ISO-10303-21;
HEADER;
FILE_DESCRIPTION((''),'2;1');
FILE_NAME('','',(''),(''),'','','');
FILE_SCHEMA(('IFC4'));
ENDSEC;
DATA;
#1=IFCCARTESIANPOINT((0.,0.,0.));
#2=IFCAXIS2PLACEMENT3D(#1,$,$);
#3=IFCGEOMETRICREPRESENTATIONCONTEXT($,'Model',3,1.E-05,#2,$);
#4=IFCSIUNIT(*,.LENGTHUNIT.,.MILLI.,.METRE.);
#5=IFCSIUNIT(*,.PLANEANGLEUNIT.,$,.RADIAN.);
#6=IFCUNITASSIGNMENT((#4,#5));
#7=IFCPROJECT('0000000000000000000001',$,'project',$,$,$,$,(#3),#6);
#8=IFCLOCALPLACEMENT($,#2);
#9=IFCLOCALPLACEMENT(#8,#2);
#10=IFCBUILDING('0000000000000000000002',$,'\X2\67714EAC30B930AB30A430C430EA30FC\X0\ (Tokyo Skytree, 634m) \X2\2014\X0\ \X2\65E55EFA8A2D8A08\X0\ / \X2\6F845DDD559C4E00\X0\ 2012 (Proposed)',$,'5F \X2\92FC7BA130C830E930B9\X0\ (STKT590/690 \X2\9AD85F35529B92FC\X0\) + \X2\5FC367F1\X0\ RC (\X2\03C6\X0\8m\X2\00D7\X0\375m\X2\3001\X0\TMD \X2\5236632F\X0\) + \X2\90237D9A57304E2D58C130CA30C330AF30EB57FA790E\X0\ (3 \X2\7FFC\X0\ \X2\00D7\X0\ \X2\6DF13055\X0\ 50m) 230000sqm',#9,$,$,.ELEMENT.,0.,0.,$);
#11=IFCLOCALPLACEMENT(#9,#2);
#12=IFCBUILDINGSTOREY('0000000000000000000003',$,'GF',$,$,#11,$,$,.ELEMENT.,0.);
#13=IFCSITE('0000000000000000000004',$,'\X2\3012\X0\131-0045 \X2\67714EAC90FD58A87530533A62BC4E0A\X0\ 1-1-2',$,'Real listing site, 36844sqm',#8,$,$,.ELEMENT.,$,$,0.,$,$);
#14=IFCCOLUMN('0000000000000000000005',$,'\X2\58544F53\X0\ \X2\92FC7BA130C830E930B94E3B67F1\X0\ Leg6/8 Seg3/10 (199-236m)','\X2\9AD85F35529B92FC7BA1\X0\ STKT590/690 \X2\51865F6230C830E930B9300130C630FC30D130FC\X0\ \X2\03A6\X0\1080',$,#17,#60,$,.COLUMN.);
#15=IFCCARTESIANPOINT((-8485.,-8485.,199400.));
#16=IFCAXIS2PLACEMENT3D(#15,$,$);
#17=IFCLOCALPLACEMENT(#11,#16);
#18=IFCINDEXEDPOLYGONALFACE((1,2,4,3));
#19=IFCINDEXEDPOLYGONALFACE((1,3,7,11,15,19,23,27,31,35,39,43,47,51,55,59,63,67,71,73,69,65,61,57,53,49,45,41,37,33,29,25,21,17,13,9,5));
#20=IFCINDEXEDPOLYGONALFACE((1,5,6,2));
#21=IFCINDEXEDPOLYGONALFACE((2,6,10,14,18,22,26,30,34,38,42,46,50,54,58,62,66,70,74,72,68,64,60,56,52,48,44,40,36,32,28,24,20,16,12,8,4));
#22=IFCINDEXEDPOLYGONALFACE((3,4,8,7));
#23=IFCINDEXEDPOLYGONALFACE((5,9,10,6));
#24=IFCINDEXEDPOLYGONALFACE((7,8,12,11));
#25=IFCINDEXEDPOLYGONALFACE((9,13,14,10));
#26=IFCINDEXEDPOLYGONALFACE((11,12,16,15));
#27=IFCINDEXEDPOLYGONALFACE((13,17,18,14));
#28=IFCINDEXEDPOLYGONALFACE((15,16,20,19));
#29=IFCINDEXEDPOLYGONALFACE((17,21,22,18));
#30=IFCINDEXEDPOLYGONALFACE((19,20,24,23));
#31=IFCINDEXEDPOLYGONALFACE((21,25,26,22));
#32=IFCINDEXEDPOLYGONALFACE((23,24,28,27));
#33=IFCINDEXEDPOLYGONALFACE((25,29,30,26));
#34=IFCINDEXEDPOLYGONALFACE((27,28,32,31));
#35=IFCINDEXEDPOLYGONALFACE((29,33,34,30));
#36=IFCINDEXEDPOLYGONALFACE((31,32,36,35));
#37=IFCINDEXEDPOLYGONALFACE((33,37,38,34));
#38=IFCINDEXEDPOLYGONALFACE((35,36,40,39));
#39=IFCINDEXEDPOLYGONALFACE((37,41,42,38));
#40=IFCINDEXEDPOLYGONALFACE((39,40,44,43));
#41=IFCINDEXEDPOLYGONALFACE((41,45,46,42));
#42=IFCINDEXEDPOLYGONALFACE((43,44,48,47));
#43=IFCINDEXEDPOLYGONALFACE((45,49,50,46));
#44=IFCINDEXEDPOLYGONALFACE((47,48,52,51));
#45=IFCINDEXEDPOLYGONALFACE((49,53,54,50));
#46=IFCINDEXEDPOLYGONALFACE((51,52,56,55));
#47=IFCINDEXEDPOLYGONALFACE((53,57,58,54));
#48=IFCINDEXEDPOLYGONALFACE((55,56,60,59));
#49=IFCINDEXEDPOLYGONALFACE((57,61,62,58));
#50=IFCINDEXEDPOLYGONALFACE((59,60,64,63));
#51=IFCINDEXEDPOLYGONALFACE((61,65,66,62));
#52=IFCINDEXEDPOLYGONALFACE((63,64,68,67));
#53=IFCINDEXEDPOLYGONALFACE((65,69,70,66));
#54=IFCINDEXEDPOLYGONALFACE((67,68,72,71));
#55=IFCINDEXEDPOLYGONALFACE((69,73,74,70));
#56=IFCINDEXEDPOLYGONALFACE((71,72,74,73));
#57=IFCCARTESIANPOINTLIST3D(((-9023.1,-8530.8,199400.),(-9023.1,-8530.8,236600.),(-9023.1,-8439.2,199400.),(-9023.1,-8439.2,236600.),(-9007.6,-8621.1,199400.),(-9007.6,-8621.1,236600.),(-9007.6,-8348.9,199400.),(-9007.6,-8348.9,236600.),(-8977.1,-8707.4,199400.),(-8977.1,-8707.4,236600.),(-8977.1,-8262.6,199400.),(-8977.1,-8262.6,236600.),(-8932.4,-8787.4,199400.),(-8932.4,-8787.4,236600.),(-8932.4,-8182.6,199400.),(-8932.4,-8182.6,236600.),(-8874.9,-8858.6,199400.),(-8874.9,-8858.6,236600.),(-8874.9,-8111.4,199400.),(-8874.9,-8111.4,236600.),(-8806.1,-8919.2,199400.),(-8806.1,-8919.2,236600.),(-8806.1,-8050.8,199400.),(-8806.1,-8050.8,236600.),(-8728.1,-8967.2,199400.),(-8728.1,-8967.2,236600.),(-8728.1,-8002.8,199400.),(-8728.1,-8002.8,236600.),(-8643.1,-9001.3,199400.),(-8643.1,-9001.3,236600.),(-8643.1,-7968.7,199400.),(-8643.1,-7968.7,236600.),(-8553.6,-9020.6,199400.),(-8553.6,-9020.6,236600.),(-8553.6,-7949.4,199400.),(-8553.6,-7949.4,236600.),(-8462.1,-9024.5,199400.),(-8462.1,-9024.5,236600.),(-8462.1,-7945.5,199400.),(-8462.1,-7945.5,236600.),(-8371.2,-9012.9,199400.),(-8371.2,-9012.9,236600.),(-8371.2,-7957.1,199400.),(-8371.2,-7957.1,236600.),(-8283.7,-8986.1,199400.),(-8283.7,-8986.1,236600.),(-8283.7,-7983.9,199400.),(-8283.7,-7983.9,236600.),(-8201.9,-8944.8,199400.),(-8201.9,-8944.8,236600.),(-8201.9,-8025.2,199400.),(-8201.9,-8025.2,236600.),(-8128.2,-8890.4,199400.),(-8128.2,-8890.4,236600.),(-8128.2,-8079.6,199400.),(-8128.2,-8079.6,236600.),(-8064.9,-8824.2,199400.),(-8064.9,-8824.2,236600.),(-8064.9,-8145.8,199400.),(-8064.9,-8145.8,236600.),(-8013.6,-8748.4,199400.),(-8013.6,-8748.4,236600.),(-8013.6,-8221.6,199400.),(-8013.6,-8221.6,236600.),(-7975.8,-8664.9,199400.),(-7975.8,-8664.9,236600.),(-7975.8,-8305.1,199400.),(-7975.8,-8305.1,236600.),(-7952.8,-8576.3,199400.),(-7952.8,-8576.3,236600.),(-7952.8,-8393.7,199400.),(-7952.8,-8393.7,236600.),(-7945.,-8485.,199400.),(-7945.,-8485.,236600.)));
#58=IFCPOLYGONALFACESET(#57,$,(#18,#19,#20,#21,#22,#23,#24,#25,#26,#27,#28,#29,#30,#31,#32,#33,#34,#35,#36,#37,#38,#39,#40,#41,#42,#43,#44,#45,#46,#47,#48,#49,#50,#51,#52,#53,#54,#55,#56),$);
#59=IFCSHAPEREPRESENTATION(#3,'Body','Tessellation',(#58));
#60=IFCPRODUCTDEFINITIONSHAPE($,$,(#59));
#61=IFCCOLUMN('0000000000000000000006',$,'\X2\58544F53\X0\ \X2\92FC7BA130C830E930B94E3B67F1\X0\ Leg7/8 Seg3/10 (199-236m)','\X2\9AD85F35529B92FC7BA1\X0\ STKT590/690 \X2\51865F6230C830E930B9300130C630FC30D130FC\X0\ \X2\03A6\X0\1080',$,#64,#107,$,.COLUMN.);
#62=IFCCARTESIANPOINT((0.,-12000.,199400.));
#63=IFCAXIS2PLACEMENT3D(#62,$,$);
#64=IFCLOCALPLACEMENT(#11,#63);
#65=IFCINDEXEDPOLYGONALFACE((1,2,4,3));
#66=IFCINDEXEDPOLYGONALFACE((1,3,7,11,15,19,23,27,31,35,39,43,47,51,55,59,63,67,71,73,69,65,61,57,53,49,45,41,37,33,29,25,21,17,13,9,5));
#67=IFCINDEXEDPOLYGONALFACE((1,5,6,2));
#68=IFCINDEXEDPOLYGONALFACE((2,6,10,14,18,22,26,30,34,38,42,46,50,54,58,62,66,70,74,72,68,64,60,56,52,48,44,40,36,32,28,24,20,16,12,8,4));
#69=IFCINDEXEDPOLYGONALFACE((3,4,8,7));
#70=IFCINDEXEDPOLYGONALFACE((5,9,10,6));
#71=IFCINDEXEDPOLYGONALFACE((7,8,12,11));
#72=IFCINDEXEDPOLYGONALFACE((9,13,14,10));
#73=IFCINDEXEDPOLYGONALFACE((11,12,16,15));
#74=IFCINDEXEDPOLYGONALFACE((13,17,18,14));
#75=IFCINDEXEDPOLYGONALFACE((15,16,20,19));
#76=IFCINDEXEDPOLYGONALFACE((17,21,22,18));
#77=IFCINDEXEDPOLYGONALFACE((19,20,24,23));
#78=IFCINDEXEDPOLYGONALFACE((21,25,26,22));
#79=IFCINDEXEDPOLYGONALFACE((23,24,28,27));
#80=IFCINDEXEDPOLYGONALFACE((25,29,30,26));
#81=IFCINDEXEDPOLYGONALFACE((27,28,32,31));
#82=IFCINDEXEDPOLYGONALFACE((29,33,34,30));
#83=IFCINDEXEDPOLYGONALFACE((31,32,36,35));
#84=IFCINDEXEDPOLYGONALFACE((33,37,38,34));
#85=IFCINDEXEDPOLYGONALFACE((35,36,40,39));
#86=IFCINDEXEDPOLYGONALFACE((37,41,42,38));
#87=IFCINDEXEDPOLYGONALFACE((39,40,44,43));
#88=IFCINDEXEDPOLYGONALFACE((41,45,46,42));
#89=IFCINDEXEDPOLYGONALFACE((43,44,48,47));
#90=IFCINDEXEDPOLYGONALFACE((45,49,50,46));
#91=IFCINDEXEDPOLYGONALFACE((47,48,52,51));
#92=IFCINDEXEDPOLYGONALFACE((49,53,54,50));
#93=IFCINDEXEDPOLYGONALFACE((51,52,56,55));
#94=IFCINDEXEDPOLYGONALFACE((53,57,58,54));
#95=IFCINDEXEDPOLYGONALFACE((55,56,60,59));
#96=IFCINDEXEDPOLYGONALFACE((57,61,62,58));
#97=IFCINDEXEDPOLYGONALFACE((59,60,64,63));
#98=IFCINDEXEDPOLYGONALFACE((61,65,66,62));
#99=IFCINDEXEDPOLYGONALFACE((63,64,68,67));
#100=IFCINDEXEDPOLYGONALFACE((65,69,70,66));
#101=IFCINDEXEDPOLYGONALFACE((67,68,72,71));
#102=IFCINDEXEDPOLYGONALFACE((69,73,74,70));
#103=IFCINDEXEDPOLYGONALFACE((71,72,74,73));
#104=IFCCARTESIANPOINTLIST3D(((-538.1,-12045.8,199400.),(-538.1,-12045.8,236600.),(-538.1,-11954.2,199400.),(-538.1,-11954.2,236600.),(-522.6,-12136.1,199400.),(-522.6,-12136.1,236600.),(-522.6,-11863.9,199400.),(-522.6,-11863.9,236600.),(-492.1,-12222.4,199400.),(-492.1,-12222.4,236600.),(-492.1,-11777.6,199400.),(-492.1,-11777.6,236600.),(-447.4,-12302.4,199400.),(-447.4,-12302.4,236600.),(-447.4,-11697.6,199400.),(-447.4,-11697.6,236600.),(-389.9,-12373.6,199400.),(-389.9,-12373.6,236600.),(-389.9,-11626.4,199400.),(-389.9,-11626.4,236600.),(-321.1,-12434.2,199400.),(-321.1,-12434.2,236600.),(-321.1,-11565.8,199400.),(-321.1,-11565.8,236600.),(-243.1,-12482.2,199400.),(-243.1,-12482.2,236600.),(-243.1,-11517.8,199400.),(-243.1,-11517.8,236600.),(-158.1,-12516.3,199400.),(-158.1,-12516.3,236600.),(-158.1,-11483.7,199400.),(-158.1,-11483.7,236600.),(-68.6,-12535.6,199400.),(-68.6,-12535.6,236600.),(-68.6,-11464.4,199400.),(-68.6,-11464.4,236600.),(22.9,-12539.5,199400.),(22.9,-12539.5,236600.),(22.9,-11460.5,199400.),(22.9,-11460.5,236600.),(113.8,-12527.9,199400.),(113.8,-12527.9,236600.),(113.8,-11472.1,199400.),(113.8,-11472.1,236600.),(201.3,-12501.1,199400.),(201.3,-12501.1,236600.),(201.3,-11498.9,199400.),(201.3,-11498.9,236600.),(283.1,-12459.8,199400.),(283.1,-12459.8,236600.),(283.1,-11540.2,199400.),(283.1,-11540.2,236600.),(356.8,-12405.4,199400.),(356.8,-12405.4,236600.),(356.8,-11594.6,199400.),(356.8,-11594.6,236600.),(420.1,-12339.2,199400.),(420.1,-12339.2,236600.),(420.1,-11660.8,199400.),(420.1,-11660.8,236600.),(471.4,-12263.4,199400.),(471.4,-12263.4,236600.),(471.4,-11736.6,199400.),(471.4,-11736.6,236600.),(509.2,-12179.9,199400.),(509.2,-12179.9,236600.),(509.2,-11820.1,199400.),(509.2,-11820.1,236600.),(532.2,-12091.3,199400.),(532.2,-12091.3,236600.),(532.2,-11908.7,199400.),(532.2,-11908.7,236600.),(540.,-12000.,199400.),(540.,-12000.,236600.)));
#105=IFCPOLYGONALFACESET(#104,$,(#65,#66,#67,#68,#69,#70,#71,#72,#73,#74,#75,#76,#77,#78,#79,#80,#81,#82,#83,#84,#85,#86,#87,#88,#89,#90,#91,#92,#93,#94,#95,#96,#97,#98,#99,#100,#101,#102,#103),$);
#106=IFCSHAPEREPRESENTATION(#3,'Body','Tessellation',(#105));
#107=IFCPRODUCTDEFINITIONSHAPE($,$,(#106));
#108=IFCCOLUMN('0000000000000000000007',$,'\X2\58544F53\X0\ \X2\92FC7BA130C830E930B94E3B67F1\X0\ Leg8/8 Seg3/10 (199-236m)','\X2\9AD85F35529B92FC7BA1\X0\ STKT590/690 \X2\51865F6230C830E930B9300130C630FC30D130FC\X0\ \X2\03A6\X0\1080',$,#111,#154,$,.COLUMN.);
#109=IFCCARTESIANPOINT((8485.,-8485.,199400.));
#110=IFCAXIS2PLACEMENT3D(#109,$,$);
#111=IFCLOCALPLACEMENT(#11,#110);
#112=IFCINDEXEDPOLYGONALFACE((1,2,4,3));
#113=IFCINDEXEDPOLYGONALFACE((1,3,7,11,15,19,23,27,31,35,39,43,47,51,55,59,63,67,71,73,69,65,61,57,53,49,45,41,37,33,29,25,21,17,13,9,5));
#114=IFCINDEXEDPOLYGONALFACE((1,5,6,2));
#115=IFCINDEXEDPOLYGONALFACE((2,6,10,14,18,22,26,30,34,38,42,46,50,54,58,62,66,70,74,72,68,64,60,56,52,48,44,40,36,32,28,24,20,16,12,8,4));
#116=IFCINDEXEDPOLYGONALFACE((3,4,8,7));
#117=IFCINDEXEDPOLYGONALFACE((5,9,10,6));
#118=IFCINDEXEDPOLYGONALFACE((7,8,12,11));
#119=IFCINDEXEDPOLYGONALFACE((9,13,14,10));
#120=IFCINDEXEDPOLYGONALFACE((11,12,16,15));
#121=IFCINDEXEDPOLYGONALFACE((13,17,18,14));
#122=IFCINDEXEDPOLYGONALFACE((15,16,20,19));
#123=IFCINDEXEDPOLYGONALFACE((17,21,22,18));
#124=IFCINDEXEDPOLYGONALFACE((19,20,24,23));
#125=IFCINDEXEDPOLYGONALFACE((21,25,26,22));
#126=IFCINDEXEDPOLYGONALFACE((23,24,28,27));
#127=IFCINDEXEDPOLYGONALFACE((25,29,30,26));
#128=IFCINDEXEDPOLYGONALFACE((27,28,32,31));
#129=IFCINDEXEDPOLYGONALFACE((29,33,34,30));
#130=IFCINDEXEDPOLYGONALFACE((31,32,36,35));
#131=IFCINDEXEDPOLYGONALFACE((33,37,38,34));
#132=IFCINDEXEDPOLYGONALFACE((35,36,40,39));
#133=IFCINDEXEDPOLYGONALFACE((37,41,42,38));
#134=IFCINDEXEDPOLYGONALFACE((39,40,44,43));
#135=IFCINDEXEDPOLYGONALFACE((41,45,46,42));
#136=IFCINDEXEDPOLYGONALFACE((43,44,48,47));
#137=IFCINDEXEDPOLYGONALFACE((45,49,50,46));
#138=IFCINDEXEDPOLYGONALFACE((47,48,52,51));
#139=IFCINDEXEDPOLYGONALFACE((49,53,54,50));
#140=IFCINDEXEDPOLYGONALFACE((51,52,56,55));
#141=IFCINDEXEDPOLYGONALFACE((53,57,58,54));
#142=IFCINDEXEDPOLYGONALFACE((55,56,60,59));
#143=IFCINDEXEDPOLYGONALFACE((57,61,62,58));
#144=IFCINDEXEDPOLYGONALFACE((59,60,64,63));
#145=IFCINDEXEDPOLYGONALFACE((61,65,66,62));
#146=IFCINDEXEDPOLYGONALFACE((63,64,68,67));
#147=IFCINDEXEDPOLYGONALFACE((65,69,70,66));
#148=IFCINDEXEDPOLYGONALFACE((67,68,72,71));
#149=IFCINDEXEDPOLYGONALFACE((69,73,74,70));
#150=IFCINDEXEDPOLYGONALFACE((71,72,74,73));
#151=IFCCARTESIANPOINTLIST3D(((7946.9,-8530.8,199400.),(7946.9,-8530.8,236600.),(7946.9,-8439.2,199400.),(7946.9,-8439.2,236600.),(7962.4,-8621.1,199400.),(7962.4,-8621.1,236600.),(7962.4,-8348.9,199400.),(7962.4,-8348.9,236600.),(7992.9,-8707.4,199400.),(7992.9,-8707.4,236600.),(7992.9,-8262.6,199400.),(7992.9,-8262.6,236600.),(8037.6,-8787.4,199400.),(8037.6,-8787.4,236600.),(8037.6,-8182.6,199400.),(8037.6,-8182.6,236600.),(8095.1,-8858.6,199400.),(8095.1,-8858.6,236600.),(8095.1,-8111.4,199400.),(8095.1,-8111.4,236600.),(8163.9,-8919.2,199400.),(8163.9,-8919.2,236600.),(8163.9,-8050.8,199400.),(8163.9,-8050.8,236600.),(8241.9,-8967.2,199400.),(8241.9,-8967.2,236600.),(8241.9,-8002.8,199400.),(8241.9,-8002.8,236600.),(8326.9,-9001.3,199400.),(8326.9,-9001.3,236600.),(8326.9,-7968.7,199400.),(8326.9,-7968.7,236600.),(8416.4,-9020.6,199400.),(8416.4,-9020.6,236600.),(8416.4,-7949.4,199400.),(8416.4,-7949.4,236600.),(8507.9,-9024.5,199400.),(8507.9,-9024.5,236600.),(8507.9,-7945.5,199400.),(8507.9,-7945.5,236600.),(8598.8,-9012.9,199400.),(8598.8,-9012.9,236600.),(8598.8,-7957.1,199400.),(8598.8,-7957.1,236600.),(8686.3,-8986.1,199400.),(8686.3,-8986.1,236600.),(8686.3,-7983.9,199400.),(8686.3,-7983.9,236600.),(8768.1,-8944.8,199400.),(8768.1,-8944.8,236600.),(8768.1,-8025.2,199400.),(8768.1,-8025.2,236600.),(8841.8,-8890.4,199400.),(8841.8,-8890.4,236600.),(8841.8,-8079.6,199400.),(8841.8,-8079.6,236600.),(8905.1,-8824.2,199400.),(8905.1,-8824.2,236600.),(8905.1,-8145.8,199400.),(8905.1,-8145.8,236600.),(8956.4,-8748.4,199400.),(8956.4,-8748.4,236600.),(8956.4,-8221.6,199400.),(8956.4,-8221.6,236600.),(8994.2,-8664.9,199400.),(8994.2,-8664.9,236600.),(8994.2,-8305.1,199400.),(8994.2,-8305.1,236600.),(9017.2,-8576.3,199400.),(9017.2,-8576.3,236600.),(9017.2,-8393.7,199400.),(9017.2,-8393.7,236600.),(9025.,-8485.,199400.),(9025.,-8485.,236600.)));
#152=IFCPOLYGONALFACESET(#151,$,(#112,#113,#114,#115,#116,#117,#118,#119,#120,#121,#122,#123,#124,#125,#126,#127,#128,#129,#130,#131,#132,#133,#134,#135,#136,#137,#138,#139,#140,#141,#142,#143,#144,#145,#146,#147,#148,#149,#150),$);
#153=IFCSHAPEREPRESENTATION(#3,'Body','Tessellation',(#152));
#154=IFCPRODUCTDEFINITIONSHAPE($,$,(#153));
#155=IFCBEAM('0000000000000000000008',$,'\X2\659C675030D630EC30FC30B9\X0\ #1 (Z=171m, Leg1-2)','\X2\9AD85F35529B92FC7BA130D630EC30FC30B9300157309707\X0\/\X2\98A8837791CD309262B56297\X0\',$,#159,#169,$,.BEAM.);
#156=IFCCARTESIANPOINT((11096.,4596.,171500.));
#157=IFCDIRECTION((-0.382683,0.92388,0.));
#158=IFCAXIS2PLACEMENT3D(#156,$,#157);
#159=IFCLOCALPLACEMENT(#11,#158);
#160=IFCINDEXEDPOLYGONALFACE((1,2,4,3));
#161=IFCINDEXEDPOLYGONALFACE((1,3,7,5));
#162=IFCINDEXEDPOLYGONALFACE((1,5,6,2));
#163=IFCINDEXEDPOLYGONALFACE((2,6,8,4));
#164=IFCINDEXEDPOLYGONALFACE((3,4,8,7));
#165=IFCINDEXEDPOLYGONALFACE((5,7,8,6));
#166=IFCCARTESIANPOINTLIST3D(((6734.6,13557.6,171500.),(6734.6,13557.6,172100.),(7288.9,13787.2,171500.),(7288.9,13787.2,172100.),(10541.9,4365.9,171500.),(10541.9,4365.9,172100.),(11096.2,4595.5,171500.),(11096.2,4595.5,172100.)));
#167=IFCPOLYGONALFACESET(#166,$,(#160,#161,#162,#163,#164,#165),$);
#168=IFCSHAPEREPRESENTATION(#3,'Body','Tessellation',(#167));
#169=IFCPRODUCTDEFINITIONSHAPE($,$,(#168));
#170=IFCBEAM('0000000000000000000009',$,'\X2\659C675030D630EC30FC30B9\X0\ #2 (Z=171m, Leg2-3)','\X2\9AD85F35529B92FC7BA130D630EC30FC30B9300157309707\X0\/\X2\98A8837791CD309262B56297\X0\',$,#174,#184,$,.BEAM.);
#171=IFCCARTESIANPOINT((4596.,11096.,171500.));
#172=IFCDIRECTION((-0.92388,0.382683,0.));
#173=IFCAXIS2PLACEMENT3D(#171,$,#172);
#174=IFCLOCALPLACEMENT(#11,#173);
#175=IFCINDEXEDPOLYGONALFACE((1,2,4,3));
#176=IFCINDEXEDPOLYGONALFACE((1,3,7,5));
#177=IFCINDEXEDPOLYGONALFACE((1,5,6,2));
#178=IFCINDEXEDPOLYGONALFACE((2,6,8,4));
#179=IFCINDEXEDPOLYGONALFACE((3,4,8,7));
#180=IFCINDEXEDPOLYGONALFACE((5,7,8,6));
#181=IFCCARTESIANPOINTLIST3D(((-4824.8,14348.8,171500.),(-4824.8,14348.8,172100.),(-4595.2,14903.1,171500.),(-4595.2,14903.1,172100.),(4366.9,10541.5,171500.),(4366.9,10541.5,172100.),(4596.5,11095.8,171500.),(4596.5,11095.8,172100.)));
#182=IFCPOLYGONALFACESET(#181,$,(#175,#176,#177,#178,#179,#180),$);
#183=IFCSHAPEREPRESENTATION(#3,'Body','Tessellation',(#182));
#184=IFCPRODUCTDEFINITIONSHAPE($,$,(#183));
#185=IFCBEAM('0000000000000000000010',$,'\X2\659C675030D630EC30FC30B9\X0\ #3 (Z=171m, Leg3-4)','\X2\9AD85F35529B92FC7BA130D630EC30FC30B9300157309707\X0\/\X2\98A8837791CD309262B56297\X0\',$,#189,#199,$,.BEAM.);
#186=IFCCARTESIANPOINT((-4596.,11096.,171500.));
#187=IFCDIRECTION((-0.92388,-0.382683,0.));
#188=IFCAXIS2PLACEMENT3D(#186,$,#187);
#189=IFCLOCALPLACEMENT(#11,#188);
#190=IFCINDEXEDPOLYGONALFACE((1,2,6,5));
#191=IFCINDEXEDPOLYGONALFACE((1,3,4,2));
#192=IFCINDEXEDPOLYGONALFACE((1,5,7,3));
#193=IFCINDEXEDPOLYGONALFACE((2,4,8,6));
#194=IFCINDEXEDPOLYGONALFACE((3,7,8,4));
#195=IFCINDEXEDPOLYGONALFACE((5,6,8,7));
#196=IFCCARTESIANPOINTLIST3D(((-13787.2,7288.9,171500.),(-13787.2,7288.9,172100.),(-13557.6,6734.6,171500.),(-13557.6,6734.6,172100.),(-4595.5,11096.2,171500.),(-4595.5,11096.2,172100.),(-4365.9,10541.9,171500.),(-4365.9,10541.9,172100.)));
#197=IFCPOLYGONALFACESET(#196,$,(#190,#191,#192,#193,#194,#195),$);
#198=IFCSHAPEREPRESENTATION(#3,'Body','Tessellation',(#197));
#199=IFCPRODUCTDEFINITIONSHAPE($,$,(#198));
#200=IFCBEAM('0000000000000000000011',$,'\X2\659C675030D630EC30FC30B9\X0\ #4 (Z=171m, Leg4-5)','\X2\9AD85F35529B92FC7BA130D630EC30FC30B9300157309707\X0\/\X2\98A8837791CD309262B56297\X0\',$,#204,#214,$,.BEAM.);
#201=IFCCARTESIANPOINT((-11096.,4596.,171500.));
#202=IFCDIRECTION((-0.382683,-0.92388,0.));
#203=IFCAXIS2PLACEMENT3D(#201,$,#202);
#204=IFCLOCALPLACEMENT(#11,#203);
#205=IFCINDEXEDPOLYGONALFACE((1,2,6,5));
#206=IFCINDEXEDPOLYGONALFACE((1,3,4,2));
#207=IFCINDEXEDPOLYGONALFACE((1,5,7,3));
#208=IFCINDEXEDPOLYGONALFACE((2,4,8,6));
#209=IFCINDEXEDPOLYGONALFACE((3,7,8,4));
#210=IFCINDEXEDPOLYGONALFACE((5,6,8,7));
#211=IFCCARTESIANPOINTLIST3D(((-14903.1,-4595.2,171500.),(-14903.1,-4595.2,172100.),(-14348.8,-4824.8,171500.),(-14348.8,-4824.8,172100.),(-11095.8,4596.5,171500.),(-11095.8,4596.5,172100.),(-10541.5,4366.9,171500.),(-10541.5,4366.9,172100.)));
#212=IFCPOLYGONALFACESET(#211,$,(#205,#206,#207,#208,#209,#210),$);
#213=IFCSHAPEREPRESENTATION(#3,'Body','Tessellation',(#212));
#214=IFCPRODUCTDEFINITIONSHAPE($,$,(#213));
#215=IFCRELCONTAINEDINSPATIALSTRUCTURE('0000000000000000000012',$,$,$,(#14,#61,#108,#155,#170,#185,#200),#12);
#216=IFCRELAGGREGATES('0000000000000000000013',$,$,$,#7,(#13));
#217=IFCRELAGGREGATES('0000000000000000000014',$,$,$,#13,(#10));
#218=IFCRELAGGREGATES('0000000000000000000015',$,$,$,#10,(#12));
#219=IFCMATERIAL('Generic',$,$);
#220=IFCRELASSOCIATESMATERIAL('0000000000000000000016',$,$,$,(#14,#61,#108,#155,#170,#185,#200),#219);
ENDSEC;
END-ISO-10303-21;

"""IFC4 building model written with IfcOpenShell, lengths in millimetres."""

from ifc_helpers import new_model, si_unit, frame, frame_2d, origin, origin_2d, place, context, project, spatial, rectangle, circle, extrude, material, element, save


model = new_model("IFC4")

# Units and contexts
model_context = context("Model", 3, precision=1e-05, world=origin())
ifc_project = project(units=[si_unit("LENGTHUNIT", "METRE", prefix="MILLI"), si_unit("PLANEANGLEUNIT", "RADIAN")], contexts=[model_context])

# Site, building, storey
site_placement = place(None, origin())
site = spatial("IfcSite", under=ifc_project, at=site_placement, Name="〒131-0045 東京都墨田区押上 1-1-2", ObjectType="Real listing site, 36844sqm", CompositionType="ELEMENT", RefElevation=0.0)
building_placement = place(site_placement, origin())
building = spatial("IfcBuilding", under=site, at=building_placement, Name="東京スカイツリー (Tokyo Skytree, 634m) — 日建設計 / 澄川喜一 2012 (Proposed)", ObjectType="5F 鋼管トラス (STKT590/690 高張力鋼) + 心柱 RC (φ8m×375m、TMD 制振) + 連続地中壁ナックル基礎 (3 翼 × 深さ 50m) 230000sqm", CompositionType="ELEMENT", ElevationOfRefHeight=0.0, ElevationOfTerrain=0.0)
storey_placement = place(building_placement, origin())
storey = spatial("IfcBuildingStorey", under=building, at=storey_placement, Name="GF", CompositionType="ELEMENT", Elevation=0.0)

# Columns
ifc_material_1 = material(Name="Generic")
column_1_placement = place(storey_placement, frame((-8485.0, -8485.0, 199400.0)))
element("IfcColumn", 1, at=column_1_placement, inside=storey, material=ifc_material_1, Name="塔体 鋼管トラス主柱 Leg6/8 Seg3/10 (199-236m)", Description="高張力鋼管 STKT590/690 円形トラス、テーパー Φ1080", PredefinedType="COLUMN", context=model_context, shape_type="SweptSolid", body=[
    extrude(circle(Radius=540.0, at=origin_2d()), frame((-8485.0, -8485.0, 199400.0)), (0.0, 0.0, 1.0), 37200.0),
])
column_2_placement = place(storey_placement, frame((0.0, -12000.0, 199400.0)))
element("IfcColumn", 2, at=column_2_placement, inside=storey, material=ifc_material_1, Name="塔体 鋼管トラス主柱 Leg7/8 Seg3/10 (199-236m)", Description="高張力鋼管 STKT590/690 円形トラス、テーパー Φ1080", PredefinedType="COLUMN", context=model_context, shape_type="SweptSolid", body=[
    extrude(circle(Radius=540.0, at=origin_2d()), frame((0.0, -12000.0, 199400.0)), (0.0, 0.0, 1.0), 37200.0),
])
column_3_placement = place(storey_placement, frame((8485.0, -8485.0, 199400.0)))
element("IfcColumn", 3, at=column_3_placement, inside=storey, material=ifc_material_1, Name="塔体 鋼管トラス主柱 Leg8/8 Seg3/10 (199-236m)", Description="高張力鋼管 STKT590/690 円形トラス、テーパー Φ1080", PredefinedType="COLUMN", context=model_context, shape_type="SweptSolid", body=[
    extrude(circle(Radius=540.0, at=origin_2d()), frame((8485.0, -8485.0, 199400.0)), (0.0, 0.0, 1.0), 37200.0),
])

# Beams
beam_1_placement = place(storey_placement, frame((11096.0, 4596.0, 171500.0), x_axis=(-0.382683, 0.92388, 0.0)))
element("IfcBeam", 4, at=beam_1_placement, inside=storey, material=ifc_material_1, Name="斜材ブレース #1 (Z=171m, Leg1-2)", Description="高張力鋼管ブレース、地震/風荷重を抵抗", PredefinedType="BEAM", context=model_context, shape_type="SweptSolid", body=[
    extrude(rectangle(XDim=9949.0, YDim=600.0, at=frame_2d((4974.0, 300.0))), frame((11096.0, 4596.0, 171500.0), x_axis=(-0.382683, 0.92388, 0.0)), (0.0, 0.0, 1.0), 600.0),
])
beam_2_placement = place(storey_placement, frame((4596.0, 11096.0, 171500.0), x_axis=(-0.92388, 0.382683, 0.0)))
element("IfcBeam", 5, at=beam_2_placement, inside=storey, material=ifc_material_1, Name="斜材ブレース #2 (Z=171m, Leg2-3)", Description="高張力鋼管ブレース、地震/風荷重を抵抗", PredefinedType="BEAM", context=model_context, shape_type="SweptSolid", body=[
    extrude(rectangle(XDim=9949.0, YDim=600.0, at=frame_2d((4974.0, 300.0))), frame((4596.0, 11096.0, 171500.0), x_axis=(-0.92388, 0.382683, 0.0)), (0.0, 0.0, 1.0), 600.0),
])
beam_3_placement = place(storey_placement, frame((-4596.0, 11096.0, 171500.0), x_axis=(-0.92388, -0.382683, 0.0)))
element("IfcBeam", 6, at=beam_3_placement, inside=storey, material=ifc_material_1, Name="斜材ブレース #3 (Z=171m, Leg3-4)", Description="高張力鋼管ブレース、地震/風荷重を抵抗", PredefinedType="BEAM", context=model_context, shape_type="SweptSolid", body=[
    extrude(rectangle(XDim=9949.0, YDim=600.0, at=frame_2d((4974.0, 300.0))), frame((-4596.0, 11096.0, 171500.0), x_axis=(-0.92388, -0.382683, 0.0)), (0.0, 0.0, 1.0), 600.0),
])
beam_4_placement = place(storey_placement, frame((-11096.0, 4596.0, 171500.0), x_axis=(-0.382683, -0.92388, 0.0)))
element("IfcBeam", 7, at=beam_4_placement, inside=storey, material=ifc_material_1, Name="斜材ブレース #4 (Z=171m, Leg4-5)", Description="高張力鋼管ブレース、地震/風荷重を抵抗", PredefinedType="BEAM", context=model_context, shape_type="SweptSolid", body=[
    extrude(rectangle(XDim=9949.0, YDim=600.0, at=frame_2d((4974.0, 300.0))), frame((-11096.0, 4596.0, 171500.0), x_axis=(-0.382683, -0.92388, 0.0)), (0.0, 0.0, 1.0), 600.0),
])

save(model, "model.ifc")
